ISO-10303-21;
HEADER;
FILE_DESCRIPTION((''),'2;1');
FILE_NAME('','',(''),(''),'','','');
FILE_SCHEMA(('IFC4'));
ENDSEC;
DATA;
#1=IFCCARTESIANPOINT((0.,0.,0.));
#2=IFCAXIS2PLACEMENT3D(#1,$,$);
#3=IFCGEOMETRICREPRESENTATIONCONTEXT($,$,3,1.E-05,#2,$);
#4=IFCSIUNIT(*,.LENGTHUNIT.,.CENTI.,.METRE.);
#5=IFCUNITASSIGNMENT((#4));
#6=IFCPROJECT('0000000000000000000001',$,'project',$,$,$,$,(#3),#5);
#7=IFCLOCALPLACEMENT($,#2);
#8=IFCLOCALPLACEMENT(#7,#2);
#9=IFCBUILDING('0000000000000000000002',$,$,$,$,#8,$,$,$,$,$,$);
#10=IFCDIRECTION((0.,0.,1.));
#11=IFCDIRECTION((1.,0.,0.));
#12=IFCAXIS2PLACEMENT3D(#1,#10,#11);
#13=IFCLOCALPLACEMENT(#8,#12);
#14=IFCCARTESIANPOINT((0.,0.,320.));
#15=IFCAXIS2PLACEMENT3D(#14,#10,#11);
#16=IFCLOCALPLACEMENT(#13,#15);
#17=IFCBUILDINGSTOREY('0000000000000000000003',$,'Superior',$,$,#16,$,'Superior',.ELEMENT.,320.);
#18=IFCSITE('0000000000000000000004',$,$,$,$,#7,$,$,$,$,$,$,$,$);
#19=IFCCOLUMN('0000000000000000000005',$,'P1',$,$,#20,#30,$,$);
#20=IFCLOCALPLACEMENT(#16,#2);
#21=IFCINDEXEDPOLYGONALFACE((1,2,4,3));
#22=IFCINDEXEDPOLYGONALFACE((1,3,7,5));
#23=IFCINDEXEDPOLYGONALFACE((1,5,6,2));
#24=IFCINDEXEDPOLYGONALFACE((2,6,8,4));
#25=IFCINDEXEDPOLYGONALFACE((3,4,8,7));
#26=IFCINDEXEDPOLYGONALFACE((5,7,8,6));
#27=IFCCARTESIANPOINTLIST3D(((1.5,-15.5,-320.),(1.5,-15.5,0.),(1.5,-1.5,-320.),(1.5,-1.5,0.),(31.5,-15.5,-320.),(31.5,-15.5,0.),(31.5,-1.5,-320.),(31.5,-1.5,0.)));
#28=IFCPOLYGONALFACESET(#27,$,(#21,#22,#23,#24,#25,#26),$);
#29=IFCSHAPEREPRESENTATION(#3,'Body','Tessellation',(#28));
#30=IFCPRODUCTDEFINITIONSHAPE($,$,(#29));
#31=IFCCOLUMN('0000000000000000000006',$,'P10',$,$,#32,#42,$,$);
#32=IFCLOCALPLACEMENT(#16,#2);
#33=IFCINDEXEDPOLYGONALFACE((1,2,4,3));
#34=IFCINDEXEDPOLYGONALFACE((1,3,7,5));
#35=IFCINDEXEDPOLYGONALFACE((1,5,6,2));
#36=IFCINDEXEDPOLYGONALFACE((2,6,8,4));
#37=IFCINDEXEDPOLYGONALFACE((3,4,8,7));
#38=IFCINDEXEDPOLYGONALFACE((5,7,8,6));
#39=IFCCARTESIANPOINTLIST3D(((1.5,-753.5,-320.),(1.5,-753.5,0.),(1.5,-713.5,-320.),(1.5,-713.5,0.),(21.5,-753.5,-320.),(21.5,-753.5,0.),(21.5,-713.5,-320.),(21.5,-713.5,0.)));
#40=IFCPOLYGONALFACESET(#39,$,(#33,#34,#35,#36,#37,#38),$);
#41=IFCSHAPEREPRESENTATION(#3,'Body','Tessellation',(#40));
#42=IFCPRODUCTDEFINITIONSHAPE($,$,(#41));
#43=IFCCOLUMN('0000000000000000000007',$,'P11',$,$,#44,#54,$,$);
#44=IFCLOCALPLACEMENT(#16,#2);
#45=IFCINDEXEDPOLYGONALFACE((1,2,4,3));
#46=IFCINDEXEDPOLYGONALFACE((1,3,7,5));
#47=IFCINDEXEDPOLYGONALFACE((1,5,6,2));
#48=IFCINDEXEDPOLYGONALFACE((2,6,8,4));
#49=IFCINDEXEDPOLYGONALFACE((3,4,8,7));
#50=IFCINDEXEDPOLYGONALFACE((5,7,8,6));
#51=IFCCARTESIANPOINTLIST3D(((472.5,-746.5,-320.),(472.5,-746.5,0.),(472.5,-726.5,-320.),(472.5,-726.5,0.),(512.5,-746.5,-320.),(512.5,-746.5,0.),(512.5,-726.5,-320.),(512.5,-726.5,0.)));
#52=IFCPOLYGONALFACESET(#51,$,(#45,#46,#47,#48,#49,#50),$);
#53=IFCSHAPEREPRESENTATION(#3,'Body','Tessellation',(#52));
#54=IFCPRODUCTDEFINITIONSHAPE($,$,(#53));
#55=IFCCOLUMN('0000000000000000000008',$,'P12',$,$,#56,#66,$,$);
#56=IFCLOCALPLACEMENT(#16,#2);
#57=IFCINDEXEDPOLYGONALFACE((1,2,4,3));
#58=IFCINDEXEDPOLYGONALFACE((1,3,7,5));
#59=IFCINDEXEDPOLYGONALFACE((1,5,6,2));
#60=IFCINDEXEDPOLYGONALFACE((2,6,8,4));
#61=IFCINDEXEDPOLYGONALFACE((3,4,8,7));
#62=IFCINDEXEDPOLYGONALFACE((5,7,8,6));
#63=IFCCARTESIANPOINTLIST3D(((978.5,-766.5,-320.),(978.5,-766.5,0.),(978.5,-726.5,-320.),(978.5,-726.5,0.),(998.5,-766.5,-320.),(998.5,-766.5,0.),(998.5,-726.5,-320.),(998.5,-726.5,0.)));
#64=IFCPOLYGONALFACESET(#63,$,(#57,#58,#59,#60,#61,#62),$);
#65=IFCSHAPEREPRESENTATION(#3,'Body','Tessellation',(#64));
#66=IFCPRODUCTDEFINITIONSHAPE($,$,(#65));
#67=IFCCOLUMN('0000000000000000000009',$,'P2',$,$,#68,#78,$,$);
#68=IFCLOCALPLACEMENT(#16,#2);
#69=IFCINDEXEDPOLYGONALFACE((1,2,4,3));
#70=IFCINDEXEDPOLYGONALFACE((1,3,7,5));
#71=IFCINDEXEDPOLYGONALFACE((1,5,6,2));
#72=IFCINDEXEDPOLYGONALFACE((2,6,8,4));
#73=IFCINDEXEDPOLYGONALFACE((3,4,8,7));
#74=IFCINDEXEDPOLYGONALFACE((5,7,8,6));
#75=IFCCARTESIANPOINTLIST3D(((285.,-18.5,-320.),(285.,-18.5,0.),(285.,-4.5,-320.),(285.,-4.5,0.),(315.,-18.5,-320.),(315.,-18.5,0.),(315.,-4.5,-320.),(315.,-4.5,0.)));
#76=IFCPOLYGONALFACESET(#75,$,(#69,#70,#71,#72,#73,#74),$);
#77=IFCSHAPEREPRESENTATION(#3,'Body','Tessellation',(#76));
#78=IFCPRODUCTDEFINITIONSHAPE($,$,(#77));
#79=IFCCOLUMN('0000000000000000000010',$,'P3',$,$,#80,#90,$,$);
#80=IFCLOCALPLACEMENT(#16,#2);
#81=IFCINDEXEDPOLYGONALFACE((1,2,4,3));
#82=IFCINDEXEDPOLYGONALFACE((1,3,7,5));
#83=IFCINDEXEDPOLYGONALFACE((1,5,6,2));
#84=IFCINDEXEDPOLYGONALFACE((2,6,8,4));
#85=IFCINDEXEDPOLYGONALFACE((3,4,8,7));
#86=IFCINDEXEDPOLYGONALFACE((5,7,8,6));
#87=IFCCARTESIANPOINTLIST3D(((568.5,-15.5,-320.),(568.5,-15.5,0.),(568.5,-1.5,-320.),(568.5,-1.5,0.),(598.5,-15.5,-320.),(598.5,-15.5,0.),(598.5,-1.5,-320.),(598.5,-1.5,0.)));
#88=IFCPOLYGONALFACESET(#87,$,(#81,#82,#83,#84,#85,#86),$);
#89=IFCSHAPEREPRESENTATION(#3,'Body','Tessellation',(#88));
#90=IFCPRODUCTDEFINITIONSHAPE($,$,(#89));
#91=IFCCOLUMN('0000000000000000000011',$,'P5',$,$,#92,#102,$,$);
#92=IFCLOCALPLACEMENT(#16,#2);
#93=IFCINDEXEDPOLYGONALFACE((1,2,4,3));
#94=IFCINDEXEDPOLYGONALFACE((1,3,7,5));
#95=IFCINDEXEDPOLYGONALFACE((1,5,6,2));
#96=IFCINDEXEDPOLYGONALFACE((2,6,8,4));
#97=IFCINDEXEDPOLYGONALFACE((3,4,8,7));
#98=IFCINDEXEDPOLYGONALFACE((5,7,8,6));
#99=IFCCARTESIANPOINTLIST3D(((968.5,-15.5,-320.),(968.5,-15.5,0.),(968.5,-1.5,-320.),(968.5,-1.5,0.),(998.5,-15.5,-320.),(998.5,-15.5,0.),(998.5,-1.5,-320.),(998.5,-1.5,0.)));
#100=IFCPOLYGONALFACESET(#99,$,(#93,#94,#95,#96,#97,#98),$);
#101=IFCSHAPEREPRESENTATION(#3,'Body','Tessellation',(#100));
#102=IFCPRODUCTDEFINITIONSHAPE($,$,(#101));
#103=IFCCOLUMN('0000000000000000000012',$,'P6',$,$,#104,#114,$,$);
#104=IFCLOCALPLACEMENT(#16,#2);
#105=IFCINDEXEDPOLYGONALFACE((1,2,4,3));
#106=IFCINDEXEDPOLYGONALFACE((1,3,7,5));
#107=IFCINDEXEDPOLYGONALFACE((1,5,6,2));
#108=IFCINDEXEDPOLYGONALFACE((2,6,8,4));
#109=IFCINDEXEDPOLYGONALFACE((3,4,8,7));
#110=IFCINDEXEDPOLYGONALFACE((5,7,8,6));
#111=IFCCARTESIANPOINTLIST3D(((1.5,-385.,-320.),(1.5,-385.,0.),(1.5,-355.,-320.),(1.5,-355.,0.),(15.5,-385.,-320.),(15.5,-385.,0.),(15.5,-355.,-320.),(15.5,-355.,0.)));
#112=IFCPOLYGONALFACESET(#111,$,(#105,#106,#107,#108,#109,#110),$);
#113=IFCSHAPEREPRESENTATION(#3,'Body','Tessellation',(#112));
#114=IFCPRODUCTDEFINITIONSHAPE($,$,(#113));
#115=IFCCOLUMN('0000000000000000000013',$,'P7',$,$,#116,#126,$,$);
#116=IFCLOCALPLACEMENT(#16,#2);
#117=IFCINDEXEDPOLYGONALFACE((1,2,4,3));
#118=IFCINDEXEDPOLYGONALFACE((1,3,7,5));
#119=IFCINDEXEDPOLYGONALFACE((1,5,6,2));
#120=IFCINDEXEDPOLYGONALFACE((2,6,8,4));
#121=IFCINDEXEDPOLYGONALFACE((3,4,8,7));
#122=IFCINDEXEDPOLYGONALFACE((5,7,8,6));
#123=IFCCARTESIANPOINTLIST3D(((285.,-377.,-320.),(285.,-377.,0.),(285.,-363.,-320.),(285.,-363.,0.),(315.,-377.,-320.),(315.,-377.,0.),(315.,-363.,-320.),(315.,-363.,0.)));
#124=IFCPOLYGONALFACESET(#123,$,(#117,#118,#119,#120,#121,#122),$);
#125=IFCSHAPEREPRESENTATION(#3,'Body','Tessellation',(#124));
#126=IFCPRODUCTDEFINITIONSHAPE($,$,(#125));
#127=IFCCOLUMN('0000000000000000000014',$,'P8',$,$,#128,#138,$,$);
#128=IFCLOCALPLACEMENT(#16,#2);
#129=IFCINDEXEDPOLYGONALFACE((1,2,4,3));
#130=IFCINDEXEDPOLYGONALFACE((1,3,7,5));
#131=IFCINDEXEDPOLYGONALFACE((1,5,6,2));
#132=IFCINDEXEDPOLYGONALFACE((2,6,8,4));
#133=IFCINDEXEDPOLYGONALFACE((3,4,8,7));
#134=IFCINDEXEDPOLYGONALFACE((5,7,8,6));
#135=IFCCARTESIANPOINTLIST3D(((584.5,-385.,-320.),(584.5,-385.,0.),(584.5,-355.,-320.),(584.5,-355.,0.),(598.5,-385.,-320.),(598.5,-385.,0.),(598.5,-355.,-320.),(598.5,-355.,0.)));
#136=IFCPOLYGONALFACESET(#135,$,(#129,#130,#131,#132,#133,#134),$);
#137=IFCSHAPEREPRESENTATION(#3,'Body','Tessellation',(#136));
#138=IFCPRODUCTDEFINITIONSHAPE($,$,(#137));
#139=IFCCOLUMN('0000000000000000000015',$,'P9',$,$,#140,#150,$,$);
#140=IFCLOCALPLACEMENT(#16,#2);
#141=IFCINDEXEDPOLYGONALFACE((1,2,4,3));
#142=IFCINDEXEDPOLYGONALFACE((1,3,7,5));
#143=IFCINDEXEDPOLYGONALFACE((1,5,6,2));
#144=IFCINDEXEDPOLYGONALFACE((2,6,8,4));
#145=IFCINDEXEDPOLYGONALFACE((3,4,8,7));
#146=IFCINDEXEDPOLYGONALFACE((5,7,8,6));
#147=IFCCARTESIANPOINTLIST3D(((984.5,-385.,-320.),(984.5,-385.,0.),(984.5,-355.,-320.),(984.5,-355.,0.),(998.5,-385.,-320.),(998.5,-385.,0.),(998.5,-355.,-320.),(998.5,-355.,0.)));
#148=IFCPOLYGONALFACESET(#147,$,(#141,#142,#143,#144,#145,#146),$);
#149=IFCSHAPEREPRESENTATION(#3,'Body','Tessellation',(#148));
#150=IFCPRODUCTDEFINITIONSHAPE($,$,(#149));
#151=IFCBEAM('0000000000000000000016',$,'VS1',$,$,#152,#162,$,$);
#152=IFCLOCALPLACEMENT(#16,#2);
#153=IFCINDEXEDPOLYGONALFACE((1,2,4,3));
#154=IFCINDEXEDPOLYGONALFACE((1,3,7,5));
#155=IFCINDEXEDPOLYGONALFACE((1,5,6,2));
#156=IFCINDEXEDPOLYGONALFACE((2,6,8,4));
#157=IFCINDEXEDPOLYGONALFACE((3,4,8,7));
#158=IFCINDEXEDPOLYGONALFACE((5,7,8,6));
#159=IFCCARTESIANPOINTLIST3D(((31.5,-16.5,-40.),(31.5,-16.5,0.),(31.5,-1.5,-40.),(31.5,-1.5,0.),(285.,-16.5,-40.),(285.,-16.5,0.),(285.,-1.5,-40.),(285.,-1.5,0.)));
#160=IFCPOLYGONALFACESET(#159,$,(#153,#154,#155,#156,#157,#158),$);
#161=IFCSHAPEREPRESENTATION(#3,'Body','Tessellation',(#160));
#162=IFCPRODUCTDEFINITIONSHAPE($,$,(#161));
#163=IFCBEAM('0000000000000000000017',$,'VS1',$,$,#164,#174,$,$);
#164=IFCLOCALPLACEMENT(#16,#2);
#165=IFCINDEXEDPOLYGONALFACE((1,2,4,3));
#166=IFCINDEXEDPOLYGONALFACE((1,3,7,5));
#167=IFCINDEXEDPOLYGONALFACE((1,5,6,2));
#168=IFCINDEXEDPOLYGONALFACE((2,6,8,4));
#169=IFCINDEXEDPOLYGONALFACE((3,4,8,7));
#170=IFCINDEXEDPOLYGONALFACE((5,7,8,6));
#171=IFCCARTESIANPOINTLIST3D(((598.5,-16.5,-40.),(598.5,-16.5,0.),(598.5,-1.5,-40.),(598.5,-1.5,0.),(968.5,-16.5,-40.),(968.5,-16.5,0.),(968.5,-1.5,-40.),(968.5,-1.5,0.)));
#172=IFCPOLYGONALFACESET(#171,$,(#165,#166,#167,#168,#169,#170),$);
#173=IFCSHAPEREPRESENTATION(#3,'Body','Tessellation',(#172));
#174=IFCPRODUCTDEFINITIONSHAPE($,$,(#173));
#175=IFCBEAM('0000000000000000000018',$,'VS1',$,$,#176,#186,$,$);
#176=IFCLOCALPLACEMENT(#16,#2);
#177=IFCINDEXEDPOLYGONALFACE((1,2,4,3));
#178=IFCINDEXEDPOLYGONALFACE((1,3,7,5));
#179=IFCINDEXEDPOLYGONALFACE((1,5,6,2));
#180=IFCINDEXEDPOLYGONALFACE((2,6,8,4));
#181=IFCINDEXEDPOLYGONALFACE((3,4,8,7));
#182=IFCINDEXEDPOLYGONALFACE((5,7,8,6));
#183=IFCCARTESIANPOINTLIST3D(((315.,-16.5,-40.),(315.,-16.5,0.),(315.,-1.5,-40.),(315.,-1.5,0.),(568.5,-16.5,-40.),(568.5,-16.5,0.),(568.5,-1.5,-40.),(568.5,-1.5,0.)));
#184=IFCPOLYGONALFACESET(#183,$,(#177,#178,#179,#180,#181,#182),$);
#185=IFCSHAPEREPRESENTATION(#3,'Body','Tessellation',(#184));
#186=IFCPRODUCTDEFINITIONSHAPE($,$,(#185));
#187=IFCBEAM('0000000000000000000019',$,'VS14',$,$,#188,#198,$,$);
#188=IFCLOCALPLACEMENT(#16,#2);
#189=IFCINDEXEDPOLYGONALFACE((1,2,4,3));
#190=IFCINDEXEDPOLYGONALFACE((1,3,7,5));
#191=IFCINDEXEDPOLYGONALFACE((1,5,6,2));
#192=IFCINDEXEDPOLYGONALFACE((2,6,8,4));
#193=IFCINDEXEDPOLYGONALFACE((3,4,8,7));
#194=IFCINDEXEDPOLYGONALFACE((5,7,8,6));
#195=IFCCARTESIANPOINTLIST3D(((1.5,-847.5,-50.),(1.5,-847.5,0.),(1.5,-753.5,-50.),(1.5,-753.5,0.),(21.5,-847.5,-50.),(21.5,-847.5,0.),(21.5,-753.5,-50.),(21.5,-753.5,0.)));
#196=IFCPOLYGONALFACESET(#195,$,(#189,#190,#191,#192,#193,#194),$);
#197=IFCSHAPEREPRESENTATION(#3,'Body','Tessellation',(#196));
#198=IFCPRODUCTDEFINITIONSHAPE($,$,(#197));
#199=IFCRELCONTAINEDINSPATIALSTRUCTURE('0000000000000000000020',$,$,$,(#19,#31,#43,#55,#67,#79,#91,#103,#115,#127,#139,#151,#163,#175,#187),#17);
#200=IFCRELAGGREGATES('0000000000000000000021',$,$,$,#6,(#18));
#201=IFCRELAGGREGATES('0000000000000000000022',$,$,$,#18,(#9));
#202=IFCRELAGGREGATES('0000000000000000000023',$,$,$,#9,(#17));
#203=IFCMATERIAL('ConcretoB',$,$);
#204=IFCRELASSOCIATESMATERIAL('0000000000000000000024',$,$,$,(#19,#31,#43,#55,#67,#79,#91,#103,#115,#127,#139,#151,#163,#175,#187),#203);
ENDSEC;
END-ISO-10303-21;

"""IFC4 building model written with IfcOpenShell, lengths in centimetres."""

from ifc_helpers import new_model, si_unit, frame, origin, origin_with_axes, place, context, project, spatial, polyline, outline, extrude, material, element, save


model = new_model("IFC4")

# Units and contexts
context_of_model = context(None, 3, precision=1e-05, world=origin())
ifc_project = project(units=[si_unit("LENGTHUNIT", "METRE", prefix="CENTI")], contexts=[context_of_model])

# Site, building, storey
site_placement = place(None, origin())
site = spatial("IfcSite", under=ifc_project, at=site_placement)
building_placement = place(site_placement, origin())
building = spatial("IfcBuilding", under=site, at=building_placement)
placement = place(building_placement, origin_with_axes())
storey_placement = place(placement, frame((0.0, 0.0, 320.0), z_axis=(0.0, 0.0, 1.0), x_axis=(1.0, 0.0, 0.0)))
storey = spatial("IfcBuildingStorey", under=building, at=storey_placement, Name="Superior", LongName="Superior", CompositionType="ELEMENT", Elevation=320.0)

# Columns
ifc_material = material(Name="ConcretoB")
column_1_placement = place(storey_placement, frame((16.5, -8.5, 0.0), z_axis=(0.0, 0.0, 1.0), x_axis=(1.0, 0.0, 0.0)))
element("IfcColumn", 1, at=column_1_placement, inside=storey, material=ifc_material, Name="P1", context=context_of_model, shape_type="SolidModel", body=[
    extrude(outline(polyline([(-15.0, 7.0), (-15.0, -7.0), (15.0, -7.0), (15.0, 7.0), (-15.0, 7.0)])), frame((0.0, 0.0, 0.0), z_axis=(0.0, 0.0, 1.0), x_axis=(1.0, 0.0, 0.0)), (0.0, 0.0, -1.0), 320.0),
])
column_2_placement = place(storey_placement, frame((11.5, -733.5, 0.0), z_axis=(0.0, 0.0, 1.0), x_axis=(1.0, 0.0, 0.0)))
element("IfcColumn", 2, at=column_2_placement, inside=storey, material=ifc_material, Name="P10", context=context_of_model, shape_type="SolidModel", body=[
    extrude(outline(polyline([(10.0, 20.0), (-10.0, 20.0), (-10.0, -20.0), (10.0, -20.0), (10.0, 20.0)])), frame((0.0, 0.0, 0.0), z_axis=(0.0, 0.0, 1.0), x_axis=(1.0, 0.0, 0.0)), (0.0, 0.0, -1.0), 320.0),
])
column_3_placement = place(storey_placement, frame((492.5, -736.5, 0.0), z_axis=(0.0, 0.0, 1.0), x_axis=(1.0, 0.0, 0.0)))
element("IfcColumn", 3, at=column_3_placement, inside=storey, material=ifc_material, Name="P11", context=context_of_model, shape_type="SolidModel", body=[
    extrude(outline(polyline([(-20.0, 10.0), (-20.0, -10.0), (20.0, -10.0), (20.0, 10.0), (-20.0, 10.0)])), origin_with_axes(), (0.0, 0.0, -1.0), 320.0),
])
column_4_placement = place(storey_placement, frame((988.5, -746.5, 0.0), z_axis=(0.0, 0.0, 1.0), x_axis=(1.0, 0.0, 0.0)))
element("IfcColumn", 4, at=column_4_placement, inside=storey, material=ifc_material, Name="P12", context=context_of_model, shape_type="SolidModel", body=[
    extrude(outline(polyline([(-10.0, -20.0), (10.0, -20.0), (10.0, 20.0), (-10.0, 20.0), (-10.0, -20.0)])), origin_with_axes(), (0.0, 0.0, -1.0), 320.0),
])
column_5_placement = place(storey_placement, frame((300.0, -11.5, 0.0), z_axis=(0.0, 0.0, 1.0), x_axis=(1.0, 0.0, 0.0)))
element("IfcColumn", 5, at=column_5_placement, inside=storey, material=ifc_material, Name="P2", context=context_of_model, shape_type="SolidModel", body=[
    extrude(outline(polyline([(15.0, -7.0), (15.0, 7.0), (-15.0, 7.0), (-15.0, -7.0), (15.0, -7.0)])), frame((0.0, 0.0, 0.0), z_axis=(0.0, 0.0, 1.0), x_axis=(1.0, 0.0, 0.0)), (0.0, 0.0, -1.0), 320.0),
])
for number, where, z_axis, x_axis, name in (
    (6, (583.5, -8.5, 0.0), (0.0, 0.0, 1.0), (1.0, 0.0, 0.0), "P3"),
    (7, (983.5, -8.5, 0.0), (0.0, 0.0, 1.0), (1.0, 0.0, 0.0), "P5"),
):
    element("IfcColumn", number, at=place(storey_placement, frame(where, z_axis=z_axis, x_axis=x_axis)), inside=storey, material=ifc_material, Name=name, context=context_of_model, shape_type="SolidModel", body=[
        extrude(outline(polyline([(-15.0, 7.0), (-15.0, -7.0), (15.0, -7.0), (15.0, 7.0), (-15.0, 7.0)])), origin_with_axes(), (0.0, 0.0, -1.0), 320.0),
    ])
column_6_placement = place(storey_placement, frame((8.5, -370.0, 0.0), z_axis=(0.0, 0.0, 1.0), x_axis=(1.0, 0.0, 0.0)))
element("IfcColumn", 8, at=column_6_placement, inside=storey, material=ifc_material, Name="P6", context=context_of_model, shape_type="SolidModel", body=[
    extrude(outline(polyline([(-7.0, -15.0), (7.0, -15.0), (7.0, 15.0), (-7.0, 15.0), (-7.0, -15.0)])), frame((0.0, 0.0, 0.0), z_axis=(0.0, 0.0, 1.0), x_axis=(1.0, 0.0, 0.0)), (0.0, 0.0, -1.0), 320.0),
])
column_7_placement = place(storey_placement, frame((300.0, -370.0, 0.0), z_axis=(0.0, 0.0, 1.0), x_axis=(1.0, 0.0, 0.0)))
element("IfcColumn", 9, at=column_7_placement, inside=storey, material=ifc_material, Name="P7", context=context_of_model, shape_type="SolidModel", body=[
    extrude(outline(polyline([(15.0, -7.0), (15.0, 7.0), (-15.0, 7.0), (-15.0, -7.0), (15.0, -7.0)])), origin_with_axes(), (0.0, 0.0, -1.0), 320.0),
])
for number, where, z_axis, x_axis, name in (
    (10, (591.5, -370.0, 0.0), (0.0, 0.0, 1.0), (1.0, 0.0, 0.0), "P8"),
    (11, (991.5, -370.0, 0.0), (0.0, 0.0, 1.0), (1.0, 0.0, 0.0), "P9"),
):
    element("IfcColumn", number, at=place(storey_placement, frame(where, z_axis=z_axis, x_axis=x_axis)), inside=storey, material=ifc_material, Name=name, context=context_of_model, shape_type="SolidModel", body=[
        extrude(outline(polyline([(7.0, 15.0), (-7.0, 15.0), (-7.0, -15.0), (7.0, -15.0), (7.0, 15.0)])), origin_with_axes(), (0.0, 0.0, -1.0), 320.0),
    ])

# Beams
beam_1_placement = place(storey_placement, frame((158.25, -9.0, 0.0), z_axis=(0.0, 0.0, 1.0), x_axis=(1.0, 0.0, 0.0)))
element("IfcBeam", 12, at=beam_1_placement, inside=storey, material=ifc_material, Name="VS1", context=context_of_model, shape_type="SolidModel", body=[
    extrude(outline(polyline([(7.5, 20.0), (-7.5, 20.0), (-7.5, -20.0), (7.5, -20.0), (7.5, 20.0)])), frame((-126.75, 0.0, -20.0), z_axis=(1.0, 0.0, 0.0), x_axis=(0.0, 1.0, 0.0)), (0.0, 0.0, 1.0), 253.5),
])
beam_2_placement = place(storey_placement, frame((783.5, -9.0, 0.0), z_axis=(0.0, 0.0, 1.0), x_axis=(1.0, 0.0, 0.0)))
element("IfcBeam", 13, at=beam_2_placement, inside=storey, material=ifc_material, Name="VS1", context=context_of_model, shape_type="SolidModel", body=[
    extrude(outline(polyline([(7.5, 20.0), (-7.5, 20.0), (-7.5, -20.0), (7.5, -20.0), (7.5, 20.0)])), frame((-185.0, 0.0, -20.0), z_axis=(1.0, 0.0, 0.0), x_axis=(0.0, 1.0, 0.0)), (0.0, 0.0, 1.0), 370.0),
])
beam_3_placement = place(storey_placement, frame((441.75, -9.0, 0.0), z_axis=(0.0, 0.0, 1.0), x_axis=(1.0, 0.0, 0.0)))
element("IfcBeam", 14, at=beam_3_placement, inside=storey, material=ifc_material, Name="VS1", context=context_of_model, shape_type="SolidModel", body=[
    extrude(outline(polyline([(7.5, 20.0), (-7.5, 20.0), (-7.5, -20.0), (7.5, -20.0), (7.5, 20.0)])), frame((-126.75, 0.0, -20.0), z_axis=(1.0, 0.0, 0.0), x_axis=(0.0, 1.0, 0.0)), (0.0, 0.0, 1.0), 253.5),
])
beam_4_placement = place(storey_placement, frame((11.5, -800.5, 0.0), z_axis=(0.0, 0.0, 1.0), x_axis=(1.0, 0.0, 0.0)))
element("IfcBeam", 15, at=beam_4_placement, inside=storey, material=ifc_material, Name="VS14", context=context_of_model, shape_type="SolidModel", body=[
    extrude(outline(polyline([(-10.0, -25.0), (10.0, -25.0), (10.0, 25.0), (-10.0, 25.0), (-10.0, -25.0)])), frame((0.0, -47.0, -25.0), z_axis=(0.0, 1.0, 0.0), x_axis=(1.0, 0.0, 0.0)), (0.0, 0.0, 1.0), 94.0),
])

save(model, "model.ifc")
